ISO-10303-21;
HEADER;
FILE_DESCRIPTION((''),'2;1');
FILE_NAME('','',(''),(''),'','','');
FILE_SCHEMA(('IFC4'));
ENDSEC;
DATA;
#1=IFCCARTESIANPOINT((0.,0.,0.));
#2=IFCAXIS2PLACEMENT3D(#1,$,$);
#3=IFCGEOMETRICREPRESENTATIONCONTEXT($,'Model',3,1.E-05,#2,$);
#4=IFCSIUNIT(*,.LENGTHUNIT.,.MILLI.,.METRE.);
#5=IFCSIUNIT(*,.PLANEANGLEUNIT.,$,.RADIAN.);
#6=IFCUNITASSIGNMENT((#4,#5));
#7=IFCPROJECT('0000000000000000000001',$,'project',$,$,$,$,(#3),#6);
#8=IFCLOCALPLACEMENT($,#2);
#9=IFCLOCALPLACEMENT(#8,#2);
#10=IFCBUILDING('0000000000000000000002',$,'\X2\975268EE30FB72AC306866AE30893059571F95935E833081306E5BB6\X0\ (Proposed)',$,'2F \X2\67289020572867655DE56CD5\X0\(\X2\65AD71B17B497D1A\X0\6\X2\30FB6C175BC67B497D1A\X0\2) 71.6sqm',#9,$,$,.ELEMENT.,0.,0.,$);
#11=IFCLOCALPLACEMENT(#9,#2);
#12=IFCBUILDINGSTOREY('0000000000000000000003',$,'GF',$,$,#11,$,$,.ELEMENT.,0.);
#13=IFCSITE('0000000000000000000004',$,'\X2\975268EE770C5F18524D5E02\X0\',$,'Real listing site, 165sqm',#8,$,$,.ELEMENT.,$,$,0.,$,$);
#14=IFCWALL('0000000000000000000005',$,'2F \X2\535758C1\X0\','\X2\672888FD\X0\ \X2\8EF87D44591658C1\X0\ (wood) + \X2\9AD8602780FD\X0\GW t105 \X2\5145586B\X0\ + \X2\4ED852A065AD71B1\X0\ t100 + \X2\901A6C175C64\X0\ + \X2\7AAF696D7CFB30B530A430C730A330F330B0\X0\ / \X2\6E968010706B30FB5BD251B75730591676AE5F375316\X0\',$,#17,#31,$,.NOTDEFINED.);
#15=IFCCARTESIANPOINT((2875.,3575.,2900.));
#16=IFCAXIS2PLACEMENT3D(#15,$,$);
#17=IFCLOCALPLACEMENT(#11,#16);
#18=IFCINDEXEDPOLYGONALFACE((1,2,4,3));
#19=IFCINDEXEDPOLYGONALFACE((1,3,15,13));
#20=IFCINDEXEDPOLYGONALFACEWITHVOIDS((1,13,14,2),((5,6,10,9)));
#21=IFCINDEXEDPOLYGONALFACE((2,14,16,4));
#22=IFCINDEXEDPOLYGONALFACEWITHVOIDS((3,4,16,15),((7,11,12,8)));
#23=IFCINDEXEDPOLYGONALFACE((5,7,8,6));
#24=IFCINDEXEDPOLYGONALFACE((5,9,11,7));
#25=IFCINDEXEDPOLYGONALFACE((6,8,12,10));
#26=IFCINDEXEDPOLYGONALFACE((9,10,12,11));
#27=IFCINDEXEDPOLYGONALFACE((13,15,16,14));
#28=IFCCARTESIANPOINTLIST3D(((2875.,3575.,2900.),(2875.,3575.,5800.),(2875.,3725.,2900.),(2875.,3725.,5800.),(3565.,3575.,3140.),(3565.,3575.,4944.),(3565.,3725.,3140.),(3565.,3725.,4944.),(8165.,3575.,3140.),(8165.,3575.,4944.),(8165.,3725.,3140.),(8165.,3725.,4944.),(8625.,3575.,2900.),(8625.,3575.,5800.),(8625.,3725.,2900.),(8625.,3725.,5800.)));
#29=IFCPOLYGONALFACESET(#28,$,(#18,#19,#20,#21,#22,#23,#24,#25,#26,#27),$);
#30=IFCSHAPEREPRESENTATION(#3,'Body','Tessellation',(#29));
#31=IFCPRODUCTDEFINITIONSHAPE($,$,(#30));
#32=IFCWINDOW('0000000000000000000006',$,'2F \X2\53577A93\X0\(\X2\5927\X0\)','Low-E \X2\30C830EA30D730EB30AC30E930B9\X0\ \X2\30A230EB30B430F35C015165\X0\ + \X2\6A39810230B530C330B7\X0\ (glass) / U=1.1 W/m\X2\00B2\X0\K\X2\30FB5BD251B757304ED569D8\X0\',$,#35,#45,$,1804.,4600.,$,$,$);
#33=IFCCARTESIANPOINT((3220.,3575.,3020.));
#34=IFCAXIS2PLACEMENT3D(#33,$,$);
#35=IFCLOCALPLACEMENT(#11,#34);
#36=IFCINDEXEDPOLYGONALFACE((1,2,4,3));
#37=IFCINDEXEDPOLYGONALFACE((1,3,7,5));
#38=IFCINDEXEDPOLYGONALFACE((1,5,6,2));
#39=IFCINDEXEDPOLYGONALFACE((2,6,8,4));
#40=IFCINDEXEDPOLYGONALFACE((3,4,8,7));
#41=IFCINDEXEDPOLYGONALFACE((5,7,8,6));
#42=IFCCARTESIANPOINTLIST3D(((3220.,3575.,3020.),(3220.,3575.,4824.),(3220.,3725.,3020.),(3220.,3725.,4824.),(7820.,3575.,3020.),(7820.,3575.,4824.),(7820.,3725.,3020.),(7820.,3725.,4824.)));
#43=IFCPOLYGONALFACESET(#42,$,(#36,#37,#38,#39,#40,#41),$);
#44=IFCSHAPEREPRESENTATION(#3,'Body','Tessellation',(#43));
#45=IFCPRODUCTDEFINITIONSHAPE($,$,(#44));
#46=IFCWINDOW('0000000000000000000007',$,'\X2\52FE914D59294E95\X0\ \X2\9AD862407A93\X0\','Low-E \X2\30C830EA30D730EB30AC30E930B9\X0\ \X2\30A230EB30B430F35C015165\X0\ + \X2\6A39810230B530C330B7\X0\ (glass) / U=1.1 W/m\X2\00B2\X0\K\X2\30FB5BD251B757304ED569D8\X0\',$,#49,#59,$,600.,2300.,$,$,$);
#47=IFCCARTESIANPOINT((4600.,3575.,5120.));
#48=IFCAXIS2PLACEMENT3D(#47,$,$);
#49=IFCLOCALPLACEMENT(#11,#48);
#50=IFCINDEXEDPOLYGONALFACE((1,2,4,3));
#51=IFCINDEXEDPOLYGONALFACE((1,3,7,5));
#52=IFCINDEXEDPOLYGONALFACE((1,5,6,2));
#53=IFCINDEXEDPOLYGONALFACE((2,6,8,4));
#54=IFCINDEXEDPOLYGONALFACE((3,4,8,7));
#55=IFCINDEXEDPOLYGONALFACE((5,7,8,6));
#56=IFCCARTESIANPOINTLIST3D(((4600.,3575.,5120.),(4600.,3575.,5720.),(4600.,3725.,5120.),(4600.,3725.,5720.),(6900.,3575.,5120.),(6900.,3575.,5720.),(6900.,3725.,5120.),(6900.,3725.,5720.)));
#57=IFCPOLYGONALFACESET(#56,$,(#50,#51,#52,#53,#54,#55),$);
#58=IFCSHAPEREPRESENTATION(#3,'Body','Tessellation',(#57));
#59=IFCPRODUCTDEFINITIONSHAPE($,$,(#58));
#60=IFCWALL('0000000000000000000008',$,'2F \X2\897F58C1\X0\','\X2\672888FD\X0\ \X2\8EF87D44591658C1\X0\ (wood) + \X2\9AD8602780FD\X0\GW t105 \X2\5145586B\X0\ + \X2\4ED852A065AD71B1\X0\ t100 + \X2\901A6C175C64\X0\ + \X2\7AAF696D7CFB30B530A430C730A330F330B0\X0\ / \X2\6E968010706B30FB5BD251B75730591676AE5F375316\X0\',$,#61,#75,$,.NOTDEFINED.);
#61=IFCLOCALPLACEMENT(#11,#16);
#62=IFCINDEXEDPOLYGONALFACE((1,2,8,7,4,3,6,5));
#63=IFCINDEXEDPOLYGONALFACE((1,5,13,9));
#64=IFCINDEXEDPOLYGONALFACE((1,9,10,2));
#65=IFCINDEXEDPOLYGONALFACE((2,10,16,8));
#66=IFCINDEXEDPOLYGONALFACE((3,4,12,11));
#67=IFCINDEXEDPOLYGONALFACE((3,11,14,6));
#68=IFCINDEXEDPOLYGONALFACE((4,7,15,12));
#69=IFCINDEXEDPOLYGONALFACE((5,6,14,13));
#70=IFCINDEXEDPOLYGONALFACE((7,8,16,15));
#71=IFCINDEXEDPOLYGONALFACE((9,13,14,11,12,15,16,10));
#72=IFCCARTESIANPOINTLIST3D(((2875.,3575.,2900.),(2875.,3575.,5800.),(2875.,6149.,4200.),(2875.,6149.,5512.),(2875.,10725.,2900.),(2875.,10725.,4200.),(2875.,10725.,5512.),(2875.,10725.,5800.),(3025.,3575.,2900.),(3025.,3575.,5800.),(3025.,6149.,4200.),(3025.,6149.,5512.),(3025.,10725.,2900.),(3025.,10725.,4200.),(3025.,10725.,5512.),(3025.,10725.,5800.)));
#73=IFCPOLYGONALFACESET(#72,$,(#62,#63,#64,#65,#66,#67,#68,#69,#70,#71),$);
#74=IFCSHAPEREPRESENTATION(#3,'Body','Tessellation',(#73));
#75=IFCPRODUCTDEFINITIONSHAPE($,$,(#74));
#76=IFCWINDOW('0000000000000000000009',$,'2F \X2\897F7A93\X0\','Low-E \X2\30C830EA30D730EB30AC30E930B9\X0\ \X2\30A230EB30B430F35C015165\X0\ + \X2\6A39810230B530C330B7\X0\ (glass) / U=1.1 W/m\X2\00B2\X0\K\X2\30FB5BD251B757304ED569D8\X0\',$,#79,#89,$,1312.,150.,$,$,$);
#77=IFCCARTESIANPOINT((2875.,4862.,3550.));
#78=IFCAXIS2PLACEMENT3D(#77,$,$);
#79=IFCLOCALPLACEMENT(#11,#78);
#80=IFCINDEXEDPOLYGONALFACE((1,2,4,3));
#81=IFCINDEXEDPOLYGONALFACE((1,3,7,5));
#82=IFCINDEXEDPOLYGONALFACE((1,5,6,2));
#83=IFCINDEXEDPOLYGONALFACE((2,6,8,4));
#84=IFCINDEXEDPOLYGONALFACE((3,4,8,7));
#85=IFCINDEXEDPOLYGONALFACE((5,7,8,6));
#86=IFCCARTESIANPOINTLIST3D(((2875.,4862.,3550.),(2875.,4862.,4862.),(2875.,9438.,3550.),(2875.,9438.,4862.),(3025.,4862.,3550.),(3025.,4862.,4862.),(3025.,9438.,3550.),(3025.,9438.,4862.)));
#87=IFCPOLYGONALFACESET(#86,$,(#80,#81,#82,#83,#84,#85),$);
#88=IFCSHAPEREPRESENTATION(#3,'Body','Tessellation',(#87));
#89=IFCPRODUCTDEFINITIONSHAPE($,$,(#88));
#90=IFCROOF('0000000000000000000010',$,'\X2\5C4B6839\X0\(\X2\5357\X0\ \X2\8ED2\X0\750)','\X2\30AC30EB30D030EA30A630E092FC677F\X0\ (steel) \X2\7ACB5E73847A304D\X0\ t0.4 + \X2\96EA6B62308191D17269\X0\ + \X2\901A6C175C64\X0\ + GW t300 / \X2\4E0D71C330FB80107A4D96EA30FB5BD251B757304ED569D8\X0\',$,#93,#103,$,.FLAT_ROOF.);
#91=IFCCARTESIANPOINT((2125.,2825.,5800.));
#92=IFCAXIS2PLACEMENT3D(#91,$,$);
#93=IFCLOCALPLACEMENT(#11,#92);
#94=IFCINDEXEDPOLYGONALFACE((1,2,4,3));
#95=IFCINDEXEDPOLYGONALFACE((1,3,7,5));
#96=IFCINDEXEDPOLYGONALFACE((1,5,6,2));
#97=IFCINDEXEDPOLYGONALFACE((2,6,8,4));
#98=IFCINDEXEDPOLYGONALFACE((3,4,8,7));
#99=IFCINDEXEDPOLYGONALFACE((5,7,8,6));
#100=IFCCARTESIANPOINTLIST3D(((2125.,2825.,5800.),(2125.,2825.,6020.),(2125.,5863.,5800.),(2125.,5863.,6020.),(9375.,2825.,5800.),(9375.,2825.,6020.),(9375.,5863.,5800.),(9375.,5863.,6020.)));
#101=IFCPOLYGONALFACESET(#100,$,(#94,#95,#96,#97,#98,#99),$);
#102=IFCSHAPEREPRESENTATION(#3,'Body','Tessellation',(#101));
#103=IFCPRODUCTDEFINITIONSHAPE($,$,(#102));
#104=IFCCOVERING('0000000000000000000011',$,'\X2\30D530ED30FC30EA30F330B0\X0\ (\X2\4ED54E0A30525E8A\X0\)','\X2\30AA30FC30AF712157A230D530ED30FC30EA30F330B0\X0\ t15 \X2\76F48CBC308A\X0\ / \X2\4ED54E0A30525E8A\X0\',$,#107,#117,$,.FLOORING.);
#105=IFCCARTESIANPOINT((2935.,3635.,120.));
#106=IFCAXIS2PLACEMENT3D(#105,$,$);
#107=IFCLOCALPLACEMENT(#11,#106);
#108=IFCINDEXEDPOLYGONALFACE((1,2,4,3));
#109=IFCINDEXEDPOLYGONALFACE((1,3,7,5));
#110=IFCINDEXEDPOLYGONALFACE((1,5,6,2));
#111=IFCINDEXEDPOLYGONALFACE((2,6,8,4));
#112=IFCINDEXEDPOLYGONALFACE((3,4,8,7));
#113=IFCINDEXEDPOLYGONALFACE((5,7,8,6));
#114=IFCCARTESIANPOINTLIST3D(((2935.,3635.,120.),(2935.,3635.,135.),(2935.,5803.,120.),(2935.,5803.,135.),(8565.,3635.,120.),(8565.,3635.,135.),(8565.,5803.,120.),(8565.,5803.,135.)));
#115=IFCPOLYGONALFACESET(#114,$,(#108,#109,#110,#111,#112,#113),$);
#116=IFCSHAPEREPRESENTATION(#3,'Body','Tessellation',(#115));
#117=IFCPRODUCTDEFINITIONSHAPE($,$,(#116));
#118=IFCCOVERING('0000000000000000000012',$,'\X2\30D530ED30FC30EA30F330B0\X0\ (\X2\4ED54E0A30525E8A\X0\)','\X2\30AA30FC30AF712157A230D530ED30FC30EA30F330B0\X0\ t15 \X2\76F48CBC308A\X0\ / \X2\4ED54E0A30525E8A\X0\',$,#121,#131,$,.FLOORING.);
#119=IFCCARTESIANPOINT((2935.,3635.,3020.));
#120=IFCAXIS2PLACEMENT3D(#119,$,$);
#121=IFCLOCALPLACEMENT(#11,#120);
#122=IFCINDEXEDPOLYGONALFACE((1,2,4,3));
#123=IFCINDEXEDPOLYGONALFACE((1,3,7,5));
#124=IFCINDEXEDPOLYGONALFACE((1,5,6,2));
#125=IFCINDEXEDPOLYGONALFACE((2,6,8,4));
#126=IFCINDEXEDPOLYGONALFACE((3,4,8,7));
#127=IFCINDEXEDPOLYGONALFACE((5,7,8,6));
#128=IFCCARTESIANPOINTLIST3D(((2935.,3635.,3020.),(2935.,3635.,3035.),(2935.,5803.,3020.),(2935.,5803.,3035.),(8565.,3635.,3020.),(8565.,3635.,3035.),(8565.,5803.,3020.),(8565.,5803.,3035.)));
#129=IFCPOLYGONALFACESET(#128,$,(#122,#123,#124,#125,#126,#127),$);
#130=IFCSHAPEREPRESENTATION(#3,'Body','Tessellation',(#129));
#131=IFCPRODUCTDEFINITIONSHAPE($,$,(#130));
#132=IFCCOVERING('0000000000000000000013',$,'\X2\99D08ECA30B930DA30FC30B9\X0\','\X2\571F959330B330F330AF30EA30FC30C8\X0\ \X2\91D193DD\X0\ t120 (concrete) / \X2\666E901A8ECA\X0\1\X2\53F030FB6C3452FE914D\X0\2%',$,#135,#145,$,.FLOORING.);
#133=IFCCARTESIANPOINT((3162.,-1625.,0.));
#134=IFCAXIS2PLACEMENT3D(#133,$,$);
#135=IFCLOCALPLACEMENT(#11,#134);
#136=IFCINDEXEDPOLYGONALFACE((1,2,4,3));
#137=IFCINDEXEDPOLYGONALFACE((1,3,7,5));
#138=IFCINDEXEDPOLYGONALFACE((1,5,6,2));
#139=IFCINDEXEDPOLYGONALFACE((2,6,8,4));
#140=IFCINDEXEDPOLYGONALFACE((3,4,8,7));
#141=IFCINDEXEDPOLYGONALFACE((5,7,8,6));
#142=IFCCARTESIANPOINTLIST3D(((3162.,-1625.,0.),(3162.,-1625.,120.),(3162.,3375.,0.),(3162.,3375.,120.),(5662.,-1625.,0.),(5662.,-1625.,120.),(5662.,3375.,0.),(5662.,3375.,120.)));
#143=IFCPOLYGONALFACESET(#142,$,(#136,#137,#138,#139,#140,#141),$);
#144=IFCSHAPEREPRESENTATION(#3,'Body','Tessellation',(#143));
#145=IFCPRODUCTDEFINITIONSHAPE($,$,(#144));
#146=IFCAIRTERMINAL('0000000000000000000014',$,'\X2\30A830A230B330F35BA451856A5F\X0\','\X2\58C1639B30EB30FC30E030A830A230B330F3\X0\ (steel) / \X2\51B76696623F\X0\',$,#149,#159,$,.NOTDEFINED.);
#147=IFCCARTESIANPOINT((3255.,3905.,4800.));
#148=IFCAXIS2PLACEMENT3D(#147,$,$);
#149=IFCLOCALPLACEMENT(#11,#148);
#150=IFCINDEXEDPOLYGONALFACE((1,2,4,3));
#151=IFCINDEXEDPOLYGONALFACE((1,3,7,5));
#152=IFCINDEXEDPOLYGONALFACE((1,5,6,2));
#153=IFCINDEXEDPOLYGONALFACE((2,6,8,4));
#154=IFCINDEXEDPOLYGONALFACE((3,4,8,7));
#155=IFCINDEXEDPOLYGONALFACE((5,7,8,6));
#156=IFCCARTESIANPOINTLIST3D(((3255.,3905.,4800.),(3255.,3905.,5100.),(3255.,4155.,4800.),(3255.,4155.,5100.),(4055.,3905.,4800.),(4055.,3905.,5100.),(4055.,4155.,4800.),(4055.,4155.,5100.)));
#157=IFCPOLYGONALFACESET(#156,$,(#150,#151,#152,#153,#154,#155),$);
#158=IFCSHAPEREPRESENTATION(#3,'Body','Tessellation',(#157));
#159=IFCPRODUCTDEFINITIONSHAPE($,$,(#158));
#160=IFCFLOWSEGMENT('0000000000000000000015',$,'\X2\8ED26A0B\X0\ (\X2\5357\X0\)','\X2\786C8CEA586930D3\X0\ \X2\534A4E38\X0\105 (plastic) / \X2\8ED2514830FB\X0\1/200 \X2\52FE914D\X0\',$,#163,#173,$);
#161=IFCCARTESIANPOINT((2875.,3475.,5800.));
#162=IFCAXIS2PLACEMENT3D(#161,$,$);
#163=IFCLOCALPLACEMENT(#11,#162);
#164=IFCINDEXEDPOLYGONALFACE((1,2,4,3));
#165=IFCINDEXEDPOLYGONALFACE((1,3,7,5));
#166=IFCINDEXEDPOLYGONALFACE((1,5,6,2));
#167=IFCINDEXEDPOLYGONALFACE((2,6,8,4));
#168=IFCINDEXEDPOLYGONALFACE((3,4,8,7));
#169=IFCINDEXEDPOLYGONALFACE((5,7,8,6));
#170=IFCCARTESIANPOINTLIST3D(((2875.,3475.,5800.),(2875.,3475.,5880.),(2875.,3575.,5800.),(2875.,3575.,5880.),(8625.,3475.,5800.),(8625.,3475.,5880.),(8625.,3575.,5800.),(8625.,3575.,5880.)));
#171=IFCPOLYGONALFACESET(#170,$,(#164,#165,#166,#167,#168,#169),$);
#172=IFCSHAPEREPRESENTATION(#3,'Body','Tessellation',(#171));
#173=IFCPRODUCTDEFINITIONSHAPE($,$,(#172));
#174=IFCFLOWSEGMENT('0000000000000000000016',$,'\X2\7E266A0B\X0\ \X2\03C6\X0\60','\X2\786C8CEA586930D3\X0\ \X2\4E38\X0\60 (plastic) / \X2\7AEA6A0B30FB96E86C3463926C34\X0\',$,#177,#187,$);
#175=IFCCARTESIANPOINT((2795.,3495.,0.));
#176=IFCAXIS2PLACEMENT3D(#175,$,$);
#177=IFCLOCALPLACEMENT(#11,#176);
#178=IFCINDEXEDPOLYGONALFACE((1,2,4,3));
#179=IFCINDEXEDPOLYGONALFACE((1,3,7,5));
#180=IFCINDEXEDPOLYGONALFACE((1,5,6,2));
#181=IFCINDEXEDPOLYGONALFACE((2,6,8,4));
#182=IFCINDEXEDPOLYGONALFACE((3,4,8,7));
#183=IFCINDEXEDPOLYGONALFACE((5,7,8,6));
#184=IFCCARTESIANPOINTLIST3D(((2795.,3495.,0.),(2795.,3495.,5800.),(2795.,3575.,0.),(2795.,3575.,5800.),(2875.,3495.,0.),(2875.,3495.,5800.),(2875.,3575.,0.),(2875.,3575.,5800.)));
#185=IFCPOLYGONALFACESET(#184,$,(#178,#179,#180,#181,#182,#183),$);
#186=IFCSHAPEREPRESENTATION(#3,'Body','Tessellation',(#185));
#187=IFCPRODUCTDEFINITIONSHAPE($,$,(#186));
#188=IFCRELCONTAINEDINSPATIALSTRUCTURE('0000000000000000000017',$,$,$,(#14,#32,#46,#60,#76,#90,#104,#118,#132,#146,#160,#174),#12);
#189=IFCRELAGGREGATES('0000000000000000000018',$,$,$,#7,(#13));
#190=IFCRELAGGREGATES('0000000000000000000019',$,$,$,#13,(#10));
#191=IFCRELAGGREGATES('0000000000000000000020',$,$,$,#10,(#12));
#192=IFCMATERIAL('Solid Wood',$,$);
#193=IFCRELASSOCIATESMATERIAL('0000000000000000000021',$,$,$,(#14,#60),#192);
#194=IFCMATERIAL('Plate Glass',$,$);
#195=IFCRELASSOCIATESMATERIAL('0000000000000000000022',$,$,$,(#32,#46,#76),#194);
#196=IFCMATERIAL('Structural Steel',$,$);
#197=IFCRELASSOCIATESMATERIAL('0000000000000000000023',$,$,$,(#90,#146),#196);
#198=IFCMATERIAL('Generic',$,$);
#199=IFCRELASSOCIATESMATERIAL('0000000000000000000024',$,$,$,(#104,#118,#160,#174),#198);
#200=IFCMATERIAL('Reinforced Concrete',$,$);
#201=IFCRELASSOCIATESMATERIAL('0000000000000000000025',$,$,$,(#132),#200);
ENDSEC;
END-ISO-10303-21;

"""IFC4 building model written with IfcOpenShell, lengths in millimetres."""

from ifc_helpers import new_model, si_unit, frame, frame_2d, origin, place, context, project, spatial, rectangle, extrude, material, element, fill, save


model = new_model("IFC4")

# Units and contexts
model_context = context("Model", 3, precision=1e-05, world=origin())
ifc_project = project(units=[si_unit("LENGTHUNIT", "METRE", prefix="MILLI"), si_unit("PLANEANGLEUNIT", "RADIAN")], contexts=[model_context])

# Site, building, storey
site_placement = place(None, origin())
site = spatial("IfcSite", under=ifc_project, at=site_placement, Name="青森県弘前市", ObjectType="Real listing site, 165sqm", CompositionType="ELEMENT", RefElevation=0.0)
building_placement = place(site_placement, origin())
building = spatial("IfcBuilding", under=site, at=building_placement, Name="青森・犬と暮らす土間広めの家 (Proposed)", ObjectType="2F 木造在来工法(断熱等級6・気密等級2) 71.6sqm", CompositionType="ELEMENT", ElevationOfRefHeight=0.0, ElevationOfTerrain=0.0)
storey_placement = place(building_placement, origin())
storey = spatial("IfcBuildingStorey", under=building, at=storey_placement, Name="GF", CompositionType="ELEMENT", Elevation=0.0)

# Shared definitions
ifc_material_1 = material(Name="Solid Wood")

# Shared definitions
ifc_material_2 = material(Name="Reinforced Concrete")

# Shared definitions
ifc_material_3 = material(Name="Plate Glass")

# Wall, openings, windows
wall_1_placement = place(storey_placement, frame((2875.0, 3575.0, 2900.0)))
wall_1 = element("IfcWall", 1, at=wall_1_placement, inside=storey, material=ifc_material_1, Name="2F 南壁", Description="木製 軸組外壁 (wood) + 高性能GW t105 充填 + 付加断熱 t100 + 通気層 + 窯業系サイディング / 準耐火・寒冷地外皮強化", PredefinedType="NOTDEFINED", context=model_context, shape_type="SweptSolid", body=[
    extrude(rectangle(XDim=5750.0, YDim=150.0, at=frame_2d((2875.0, 75.0))), frame((2875.0, 3575.0, 2900.0)), (0.0, 0.0, 1.0), 2900.0),
])
opening_1_placement = place(storey_placement, frame((3220.0, 3575.0, 3020.0)))
opening_1 = element("IfcOpeningElement", 2, at=opening_1_placement, cuts=wall_1, PredefinedType="NOTDEFINED", context=model_context, shape_type="SweptSolid", body=[
    extrude(rectangle(XDim=4600.0, YDim=150.0, at=frame_2d((2300.0, 75.0))), frame((3220.0, 3575.0, 3020.0)), (0.0, 0.0, 1.0), 1804.0),
])
opening_2_placement = place(storey_placement, frame((4600.0, 3575.0, 5120.0)))
opening_2 = element("IfcOpeningElement", 3, at=opening_2_placement, cuts=wall_1, PredefinedType="NOTDEFINED", context=model_context, shape_type="SweptSolid", body=[
    extrude(rectangle(XDim=2300.0, YDim=150.0, at=frame_2d((1150.0, 75.0))), frame((4600.0, 3575.0, 5120.0)), (0.0, 0.0, 1.0), 600.0),
])
window_1_placement = place(storey_placement, frame((3220.0, 3575.0, 3020.0)))
window_1 = element("IfcWindow", 4, at=window_1_placement, inside=storey, material=ifc_material_3, Name="2F 南窓(大)", Description="Low-E トリプルガラス アルゴン封入 + 樹脂サッシ (glass) / U=1.1 W/m²K・寒冷地仕様", OverallHeight=1804.0, OverallWidth=4600.0, context=model_context, shape_type="SweptSolid", body=[
    extrude(rectangle(XDim=4600.0, YDim=150.0, at=frame_2d((2300.0, 75.0))), frame((3220.0, 3575.0, 3020.0)), (0.0, 0.0, 1.0), 1804.0),
])
fill(opening_1, window_1)
window_2_placement = place(storey_placement, frame((4600.0, 3575.0, 5120.0)))
window_2 = element("IfcWindow", 5, at=window_2_placement, inside=storey, material=ifc_material_3, Name="勾配天井 高所窓", Description="Low-E トリプルガラス アルゴン封入 + 樹脂サッシ (glass) / U=1.1 W/m²K・寒冷地仕様", OverallHeight=600.0, OverallWidth=2300.0, context=model_context, shape_type="SweptSolid", body=[
    extrude(rectangle(XDim=2300.0, YDim=150.0, at=frame_2d((1150.0, 75.0))), frame((4600.0, 3575.0, 5120.0)), (0.0, 0.0, 1.0), 600.0),
])
fill(opening_2, window_2)

# Wall, opening, window
wall_2_placement = place(storey_placement, frame((2875.0, 3575.0, 2900.0)))
wall_2 = element("IfcWall", 6, at=wall_2_placement, inside=storey, material=ifc_material_1, Name="2F 西壁", Description="木製 軸組外壁 (wood) + 高性能GW t105 充填 + 付加断熱 t100 + 通気層 + 窯業系サイディング / 準耐火・寒冷地外皮強化", PredefinedType="NOTDEFINED", context=model_context, shape_type="SweptSolid", body=[
    extrude(rectangle(XDim=150.0, YDim=7150.0, at=frame_2d((75.0, 3575.0))), frame((2875.0, 3575.0, 2900.0)), (0.0, 0.0, 1.0), 2900.0),
])
opening_3_placement = place(storey_placement, frame((2875.0, 4862.0, 3550.0)))
opening_3 = element("IfcOpeningElement", 7, at=opening_3_placement, cuts=wall_2, PredefinedType="NOTDEFINED", context=model_context, shape_type="SweptSolid", body=[
    extrude(rectangle(XDim=150.0, YDim=4576.0, at=frame_2d((75.0, 2288.0))), frame((2875.0, 4862.0, 3550.0)), (0.0, 0.0, 1.0), 1312.0),
])
window_3_placement = place(storey_placement, frame((2875.0, 4862.0, 3550.0)))
window_3 = element("IfcWindow", 8, at=window_3_placement, inside=storey, material=ifc_material_3, Name="2F 西窓", Description="Low-E トリプルガラス アルゴン封入 + 樹脂サッシ (glass) / U=1.1 W/m²K・寒冷地仕様", OverallHeight=1312.0, OverallWidth=150.0, context=model_context, shape_type="SweptSolid", body=[
    extrude(rectangle(XDim=150.0, YDim=4576.0, at=frame_2d((75.0, 2288.0))), frame((2875.0, 4862.0, 3550.0)), (0.0, 0.0, 1.0), 1312.0),
])
fill(opening_3, window_3)

# Roof
ifc_material_4 = material(Name="Structural Steel")
for number, where, name in (
    (9, (2125.0, 2825.0, 5800.0), "屋根(南 軒750)"),
):
    element("IfcRoof", number, at=place(storey_placement, frame(where)), inside=storey, material=ifc_material_4, Name=name, Description="ガルバリウム鋼板 (steel) 立平葺き t0.4 + 雪止め金物 + 通気層 + GW t300 / 不燃・耐積雪・寒冷地仕様", PredefinedType="FLAT_ROOF", context=model_context, shape_type="SweptSolid", body=[
        extrude(rectangle(XDim=7250.0, YDim=3038.0, at=frame_2d((3625.0, 1519.0))), frame((2125.0, 2825.0, 5800.0)), (0.0, 0.0, 1.0), 220.0),
    ])

# Coverings
ifc_material_5 = material(Name="Generic")
covering_1_placement = place(storey_placement, frame((2935.0, 3635.0, 120.0)))
element("IfcCovering", 10, at=covering_1_placement, inside=storey, material=ifc_material_5, Name="フローリング (仕上げ床)", Description="オーク無垢フローリング t15 直貼り / 仕上げ床", PredefinedType="FLOORING", context=model_context, shape_type="SweptSolid", body=[
    extrude(rectangle(XDim=5630.0, YDim=2168.0, at=frame_2d((2815.0, 1084.0))), frame((2935.0, 3635.0, 120.0)), (0.0, 0.0, 1.0), 15.0),
])
covering_2_placement = place(storey_placement, frame((2935.0, 3635.0, 3020.0)))
element("IfcCovering", 11, at=covering_2_placement, inside=storey, material=ifc_material_5, Name="フローリング (仕上げ床)", Description="オーク無垢フローリング t15 直貼り / 仕上げ床", PredefinedType="FLOORING", context=model_context, shape_type="SweptSolid", body=[
    extrude(rectangle(XDim=5630.0, YDim=2168.0, at=frame_2d((2815.0, 1084.0))), frame((2935.0, 3635.0, 3020.0)), (0.0, 0.0, 1.0), 15.0),
])
covering_3_placement = place(storey_placement, frame((3162.0, -1625.0, 0.0)))
element("IfcCovering", 12, at=covering_3_placement, inside=storey, material=ifc_material_2, Name="駐車スペース", Description="土間コンクリート 金鏝 t120 (concrete) / 普通車1台・水勾配2%", PredefinedType="FLOORING", context=model_context, shape_type="SweptSolid", body=[
    extrude(rectangle(XDim=2500.0, YDim=5000.0, at=frame_2d((1250.0, 2500.0))), frame((3162.0, -1625.0, 0.0)), (0.0, 0.0, 1.0), 120.0),
])

# Air terminal
air_terminal_placement = place(storey_placement, frame((3255.0, 3905.0, 4800.0)))
element("IfcAirTerminal", 13, at=air_terminal_placement, inside=storey, material=ifc_material_4, Name="エアコン室内機", Description="壁掛ルームエアコン (steel) / 冷暖房", PredefinedType="NOTDEFINED", context=model_context, shape_type="SweptSolid", body=[
    extrude(rectangle(XDim=800.0, YDim=250.0, at=frame_2d((400.0, 125.0))), frame((3255.0, 3905.0, 4800.0)), (0.0, 0.0, 1.0), 300.0),
])

# Flow segments
flow_segment_1_placement = place(storey_placement, frame((2875.0, 3475.0, 5800.0)))
element("IfcFlowSegment", 14, at=flow_segment_1_placement, inside=storey, material=ifc_material_5, Name="軒樋 (南)", Description="硬質塩ビ 半丸105 (plastic) / 軒先・1/200 勾配", context=model_context, shape_type="SweptSolid", body=[
    extrude(rectangle(XDim=5750.0, YDim=100.0, at=frame_2d((2875.0, 50.0))), frame((2875.0, 3475.0, 5800.0)), (0.0, 0.0, 1.0), 80.0),
])
flow_segment_2_placement = place(storey_placement, frame((2795.0, 3495.0, 0.0)))
element("IfcFlowSegment", 15, at=flow_segment_2_placement, inside=storey, material=ifc_material_5, Name="縦樋 φ60", Description="硬質塩ビ 丸60 (plastic) / 竪樋・雨水排水", context=model_context, shape_type="SweptSolid", body=[
    extrude(rectangle(XDim=80.0, YDim=80.0, at=frame_2d((40.0, 40.0))), frame((2795.0, 3495.0, 0.0)), (0.0, 0.0, 1.0), 5800.0),
])

save(model, "model.ifc")
